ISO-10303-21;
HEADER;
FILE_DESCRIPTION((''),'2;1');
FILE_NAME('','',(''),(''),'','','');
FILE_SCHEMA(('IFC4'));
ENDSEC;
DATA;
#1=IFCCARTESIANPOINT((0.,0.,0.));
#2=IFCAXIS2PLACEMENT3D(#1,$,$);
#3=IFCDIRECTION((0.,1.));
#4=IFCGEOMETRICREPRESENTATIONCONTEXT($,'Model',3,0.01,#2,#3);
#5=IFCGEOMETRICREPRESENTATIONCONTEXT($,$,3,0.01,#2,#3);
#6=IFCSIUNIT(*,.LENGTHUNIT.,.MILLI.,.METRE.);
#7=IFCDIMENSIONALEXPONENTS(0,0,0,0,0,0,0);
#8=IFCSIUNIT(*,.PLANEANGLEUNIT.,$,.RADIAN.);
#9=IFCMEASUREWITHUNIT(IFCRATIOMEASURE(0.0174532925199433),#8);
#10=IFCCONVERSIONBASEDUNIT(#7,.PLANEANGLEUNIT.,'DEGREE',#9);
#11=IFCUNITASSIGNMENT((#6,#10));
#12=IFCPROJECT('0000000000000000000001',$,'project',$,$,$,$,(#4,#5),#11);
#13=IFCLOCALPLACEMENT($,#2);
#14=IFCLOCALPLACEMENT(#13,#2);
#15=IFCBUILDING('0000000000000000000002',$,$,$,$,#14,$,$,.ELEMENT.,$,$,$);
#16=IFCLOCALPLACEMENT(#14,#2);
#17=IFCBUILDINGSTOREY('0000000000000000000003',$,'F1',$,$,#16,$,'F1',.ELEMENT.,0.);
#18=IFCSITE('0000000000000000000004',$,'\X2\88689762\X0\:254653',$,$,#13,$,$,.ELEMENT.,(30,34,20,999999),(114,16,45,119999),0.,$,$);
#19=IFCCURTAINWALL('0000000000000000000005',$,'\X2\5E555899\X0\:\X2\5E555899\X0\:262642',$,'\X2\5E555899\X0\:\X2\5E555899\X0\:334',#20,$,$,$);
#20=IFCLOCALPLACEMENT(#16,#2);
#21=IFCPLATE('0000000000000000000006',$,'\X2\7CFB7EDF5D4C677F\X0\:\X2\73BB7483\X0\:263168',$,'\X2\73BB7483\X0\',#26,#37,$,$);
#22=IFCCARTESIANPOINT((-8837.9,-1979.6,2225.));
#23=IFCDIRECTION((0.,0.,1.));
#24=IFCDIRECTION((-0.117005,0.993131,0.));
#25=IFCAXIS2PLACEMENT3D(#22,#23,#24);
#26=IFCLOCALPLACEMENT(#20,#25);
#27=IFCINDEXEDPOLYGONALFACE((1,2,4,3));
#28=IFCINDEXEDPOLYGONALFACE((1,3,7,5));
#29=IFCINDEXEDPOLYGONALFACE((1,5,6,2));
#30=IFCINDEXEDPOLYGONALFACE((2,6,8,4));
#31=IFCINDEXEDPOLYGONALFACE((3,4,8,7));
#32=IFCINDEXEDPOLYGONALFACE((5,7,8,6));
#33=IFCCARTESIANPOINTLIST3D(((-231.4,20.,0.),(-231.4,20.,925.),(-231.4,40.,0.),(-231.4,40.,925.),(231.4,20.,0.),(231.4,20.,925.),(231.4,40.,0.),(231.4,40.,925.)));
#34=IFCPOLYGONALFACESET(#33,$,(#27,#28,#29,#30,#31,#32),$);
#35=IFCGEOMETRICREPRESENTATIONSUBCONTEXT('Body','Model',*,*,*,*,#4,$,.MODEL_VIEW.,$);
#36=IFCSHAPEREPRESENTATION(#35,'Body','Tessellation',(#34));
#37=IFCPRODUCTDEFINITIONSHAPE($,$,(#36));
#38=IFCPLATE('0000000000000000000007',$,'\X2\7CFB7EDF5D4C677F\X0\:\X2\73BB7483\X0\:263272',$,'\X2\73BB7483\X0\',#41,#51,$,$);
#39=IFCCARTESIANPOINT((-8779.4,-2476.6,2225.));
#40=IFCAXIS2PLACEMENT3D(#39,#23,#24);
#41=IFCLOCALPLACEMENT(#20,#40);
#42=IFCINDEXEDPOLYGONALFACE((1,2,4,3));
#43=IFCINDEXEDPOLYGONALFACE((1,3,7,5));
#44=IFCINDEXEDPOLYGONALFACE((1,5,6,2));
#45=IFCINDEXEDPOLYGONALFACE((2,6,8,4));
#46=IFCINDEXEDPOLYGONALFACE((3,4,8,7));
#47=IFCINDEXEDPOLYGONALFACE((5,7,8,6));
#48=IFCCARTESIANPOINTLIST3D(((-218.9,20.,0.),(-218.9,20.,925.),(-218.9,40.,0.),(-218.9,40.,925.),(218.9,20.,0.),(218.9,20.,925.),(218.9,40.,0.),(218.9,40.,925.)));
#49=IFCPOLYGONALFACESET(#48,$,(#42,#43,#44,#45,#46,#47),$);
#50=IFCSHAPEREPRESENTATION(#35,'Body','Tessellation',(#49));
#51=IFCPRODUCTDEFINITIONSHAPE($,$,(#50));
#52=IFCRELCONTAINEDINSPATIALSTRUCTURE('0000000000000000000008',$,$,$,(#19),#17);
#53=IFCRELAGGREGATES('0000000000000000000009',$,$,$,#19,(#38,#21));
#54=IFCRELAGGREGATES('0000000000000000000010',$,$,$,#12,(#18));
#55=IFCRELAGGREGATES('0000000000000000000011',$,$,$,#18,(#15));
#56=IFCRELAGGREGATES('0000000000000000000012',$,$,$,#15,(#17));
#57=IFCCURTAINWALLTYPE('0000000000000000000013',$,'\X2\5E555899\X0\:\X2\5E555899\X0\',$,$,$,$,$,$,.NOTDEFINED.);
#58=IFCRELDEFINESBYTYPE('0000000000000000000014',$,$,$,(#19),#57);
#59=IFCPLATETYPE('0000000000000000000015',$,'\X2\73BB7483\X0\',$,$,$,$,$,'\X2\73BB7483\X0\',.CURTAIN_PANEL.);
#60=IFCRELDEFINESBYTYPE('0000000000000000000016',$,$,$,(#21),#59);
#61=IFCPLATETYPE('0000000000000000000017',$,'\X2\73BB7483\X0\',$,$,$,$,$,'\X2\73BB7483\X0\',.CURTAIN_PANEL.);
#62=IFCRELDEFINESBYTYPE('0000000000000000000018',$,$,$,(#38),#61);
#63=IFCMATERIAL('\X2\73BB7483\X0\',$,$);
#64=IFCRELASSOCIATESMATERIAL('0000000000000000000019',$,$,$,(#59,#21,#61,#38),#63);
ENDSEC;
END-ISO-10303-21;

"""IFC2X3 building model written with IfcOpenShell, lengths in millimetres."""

from ifc_helpers import new_model, entity, si_unit, converted_unit, direction, frame, frame_2d, origin, place, context, subcontext, project, spatial, rectangle, extrude, source, transform, mapped, material, type_object, type_shapes, element, aggregate, save


model = new_model("IFC2X3")

# Units and contexts
model_context = context("Model", 3, precision=0.01, world=origin(), true_north=direction((0.0, 1.0)))
context_of_model = context(None, 3, precision=0.01, world=origin(), true_north=direction((0.0, 1.0)))
body_context = subcontext(model_context, "Body", "Model", "MODEL_VIEW")
ifc_project = project(units=[si_unit("LENGTHUNIT", "METRE", prefix="MILLI"), converted_unit("PLANEANGLEUNIT", "DEGREE", entity("IfcRatioMeasure", 0.0174532925199433), si_unit("PLANEANGLEUNIT", "RADIAN"), dimensions=[0, 0, 0, 0, 0, 0, 0])], contexts=[model_context, context_of_model])

# Site, building, storey
site_placement = place(None, origin())
site = spatial("IfcSite", under=ifc_project, at=site_placement, Name="表面:254653", CompositionType="ELEMENT", RefLatitude=(30, 34, 20, 999999), RefLongitude=(114, 16, 45, 119999), RefElevation=0.0)
building_placement = place(site_placement, origin())
building = spatial("IfcBuilding", under=site, at=building_placement, CompositionType="ELEMENT")
storey_placement = place(building_placement, origin())
storey = spatial("IfcBuildingStorey", under=building, at=storey_placement, Name="F1", LongName="F1", CompositionType="ELEMENT", Elevation=0.0)

# Curtain wall, plates
ifc_material_1 = material(Name="玻璃")
curtain_wall_type_1 = type_object("IfcCurtainWallType", Name="幕墙:幕墙", PredefinedType="NOTDEFINED")
curtain_wall_1_placement = place(storey_placement, origin())
curtain_wall_1 = element("IfcCurtainWall", 1, at=curtain_wall_1_placement, inside=storey, type_object=curtain_wall_type_1, Name="幕墙:幕墙:262642", ObjectType="幕墙:幕墙:334")
plate_type_1 = type_object("IfcPlateType", Name="玻璃", ElementType="玻璃", PredefinedType="CURTAIN_PANEL", material=ifc_material_1)
shared_shape_1 = source(origin(), body_context, "Body", "SweptSolid", [
    extrude(rectangle(XDim=20.0, YDim=462.9, at=frame_2d((0.0, 0.0), x_axis=(1.0, 0.0))), frame((0.0, 30.0, 0.0), z_axis=(0.0, 0.0, 1.0), x_axis=(0.0, 1.0, 0.0)), (0.0, 0.0, 1.0), 925.0),
])
type_shapes(plate_type_1, [shared_shape_1])
plate_1_placement = place(curtain_wall_1_placement, frame((-8837.9, -1979.6, 2225.0), z_axis=(0.0, 0.0, 1.0), x_axis=(-0.117005, 0.993131, 0.0)))
plate_1 = element("IfcPlate", 2, at=plate_1_placement, type_object=plate_type_1, material=ifc_material_1, Name="系统嵌板:玻璃:263168", ObjectType="玻璃", context=body_context, shape_type="MappedRepresentation", body=[
    mapped(shared_shape_1, transform((0.0, 0.0, 0.0), scale=1.0)),
])
plate_type_2 = type_object("IfcPlateType", Name="玻璃", ElementType="玻璃", PredefinedType="CURTAIN_PANEL", material=ifc_material_1)
shared_shape_2 = source(origin(), body_context, "Body", "SweptSolid", [
    extrude(rectangle(XDim=20.0, YDim=437.9, at=frame_2d((0.0, 0.0), x_axis=(1.0, 0.0))), frame((0.0, 30.0, 0.0), z_axis=(0.0, 0.0, 1.0), x_axis=(0.0, 1.0, 0.0)), (0.0, 0.0, 1.0), 925.0),
])
type_shapes(plate_type_2, [shared_shape_2])
plate_2_placement = place(curtain_wall_1_placement, frame((-8779.4, -2476.6, 2225.0), z_axis=(0.0, 0.0, 1.0), x_axis=(-0.117005, 0.993131, 0.0)))
plate_2 = element("IfcPlate", 3, at=plate_2_placement, type_object=plate_type_2, material=ifc_material_1, Name="系统嵌板:玻璃:263272", ObjectType="玻璃", context=body_context, shape_type="MappedRepresentation", body=[
    mapped(shared_shape_2, transform((0.0, 0.0, 0.0), scale=1.0)),
])

aggregate(curtain_wall_1, [plate_2, plate_1])

save(model, "model.ifc")
